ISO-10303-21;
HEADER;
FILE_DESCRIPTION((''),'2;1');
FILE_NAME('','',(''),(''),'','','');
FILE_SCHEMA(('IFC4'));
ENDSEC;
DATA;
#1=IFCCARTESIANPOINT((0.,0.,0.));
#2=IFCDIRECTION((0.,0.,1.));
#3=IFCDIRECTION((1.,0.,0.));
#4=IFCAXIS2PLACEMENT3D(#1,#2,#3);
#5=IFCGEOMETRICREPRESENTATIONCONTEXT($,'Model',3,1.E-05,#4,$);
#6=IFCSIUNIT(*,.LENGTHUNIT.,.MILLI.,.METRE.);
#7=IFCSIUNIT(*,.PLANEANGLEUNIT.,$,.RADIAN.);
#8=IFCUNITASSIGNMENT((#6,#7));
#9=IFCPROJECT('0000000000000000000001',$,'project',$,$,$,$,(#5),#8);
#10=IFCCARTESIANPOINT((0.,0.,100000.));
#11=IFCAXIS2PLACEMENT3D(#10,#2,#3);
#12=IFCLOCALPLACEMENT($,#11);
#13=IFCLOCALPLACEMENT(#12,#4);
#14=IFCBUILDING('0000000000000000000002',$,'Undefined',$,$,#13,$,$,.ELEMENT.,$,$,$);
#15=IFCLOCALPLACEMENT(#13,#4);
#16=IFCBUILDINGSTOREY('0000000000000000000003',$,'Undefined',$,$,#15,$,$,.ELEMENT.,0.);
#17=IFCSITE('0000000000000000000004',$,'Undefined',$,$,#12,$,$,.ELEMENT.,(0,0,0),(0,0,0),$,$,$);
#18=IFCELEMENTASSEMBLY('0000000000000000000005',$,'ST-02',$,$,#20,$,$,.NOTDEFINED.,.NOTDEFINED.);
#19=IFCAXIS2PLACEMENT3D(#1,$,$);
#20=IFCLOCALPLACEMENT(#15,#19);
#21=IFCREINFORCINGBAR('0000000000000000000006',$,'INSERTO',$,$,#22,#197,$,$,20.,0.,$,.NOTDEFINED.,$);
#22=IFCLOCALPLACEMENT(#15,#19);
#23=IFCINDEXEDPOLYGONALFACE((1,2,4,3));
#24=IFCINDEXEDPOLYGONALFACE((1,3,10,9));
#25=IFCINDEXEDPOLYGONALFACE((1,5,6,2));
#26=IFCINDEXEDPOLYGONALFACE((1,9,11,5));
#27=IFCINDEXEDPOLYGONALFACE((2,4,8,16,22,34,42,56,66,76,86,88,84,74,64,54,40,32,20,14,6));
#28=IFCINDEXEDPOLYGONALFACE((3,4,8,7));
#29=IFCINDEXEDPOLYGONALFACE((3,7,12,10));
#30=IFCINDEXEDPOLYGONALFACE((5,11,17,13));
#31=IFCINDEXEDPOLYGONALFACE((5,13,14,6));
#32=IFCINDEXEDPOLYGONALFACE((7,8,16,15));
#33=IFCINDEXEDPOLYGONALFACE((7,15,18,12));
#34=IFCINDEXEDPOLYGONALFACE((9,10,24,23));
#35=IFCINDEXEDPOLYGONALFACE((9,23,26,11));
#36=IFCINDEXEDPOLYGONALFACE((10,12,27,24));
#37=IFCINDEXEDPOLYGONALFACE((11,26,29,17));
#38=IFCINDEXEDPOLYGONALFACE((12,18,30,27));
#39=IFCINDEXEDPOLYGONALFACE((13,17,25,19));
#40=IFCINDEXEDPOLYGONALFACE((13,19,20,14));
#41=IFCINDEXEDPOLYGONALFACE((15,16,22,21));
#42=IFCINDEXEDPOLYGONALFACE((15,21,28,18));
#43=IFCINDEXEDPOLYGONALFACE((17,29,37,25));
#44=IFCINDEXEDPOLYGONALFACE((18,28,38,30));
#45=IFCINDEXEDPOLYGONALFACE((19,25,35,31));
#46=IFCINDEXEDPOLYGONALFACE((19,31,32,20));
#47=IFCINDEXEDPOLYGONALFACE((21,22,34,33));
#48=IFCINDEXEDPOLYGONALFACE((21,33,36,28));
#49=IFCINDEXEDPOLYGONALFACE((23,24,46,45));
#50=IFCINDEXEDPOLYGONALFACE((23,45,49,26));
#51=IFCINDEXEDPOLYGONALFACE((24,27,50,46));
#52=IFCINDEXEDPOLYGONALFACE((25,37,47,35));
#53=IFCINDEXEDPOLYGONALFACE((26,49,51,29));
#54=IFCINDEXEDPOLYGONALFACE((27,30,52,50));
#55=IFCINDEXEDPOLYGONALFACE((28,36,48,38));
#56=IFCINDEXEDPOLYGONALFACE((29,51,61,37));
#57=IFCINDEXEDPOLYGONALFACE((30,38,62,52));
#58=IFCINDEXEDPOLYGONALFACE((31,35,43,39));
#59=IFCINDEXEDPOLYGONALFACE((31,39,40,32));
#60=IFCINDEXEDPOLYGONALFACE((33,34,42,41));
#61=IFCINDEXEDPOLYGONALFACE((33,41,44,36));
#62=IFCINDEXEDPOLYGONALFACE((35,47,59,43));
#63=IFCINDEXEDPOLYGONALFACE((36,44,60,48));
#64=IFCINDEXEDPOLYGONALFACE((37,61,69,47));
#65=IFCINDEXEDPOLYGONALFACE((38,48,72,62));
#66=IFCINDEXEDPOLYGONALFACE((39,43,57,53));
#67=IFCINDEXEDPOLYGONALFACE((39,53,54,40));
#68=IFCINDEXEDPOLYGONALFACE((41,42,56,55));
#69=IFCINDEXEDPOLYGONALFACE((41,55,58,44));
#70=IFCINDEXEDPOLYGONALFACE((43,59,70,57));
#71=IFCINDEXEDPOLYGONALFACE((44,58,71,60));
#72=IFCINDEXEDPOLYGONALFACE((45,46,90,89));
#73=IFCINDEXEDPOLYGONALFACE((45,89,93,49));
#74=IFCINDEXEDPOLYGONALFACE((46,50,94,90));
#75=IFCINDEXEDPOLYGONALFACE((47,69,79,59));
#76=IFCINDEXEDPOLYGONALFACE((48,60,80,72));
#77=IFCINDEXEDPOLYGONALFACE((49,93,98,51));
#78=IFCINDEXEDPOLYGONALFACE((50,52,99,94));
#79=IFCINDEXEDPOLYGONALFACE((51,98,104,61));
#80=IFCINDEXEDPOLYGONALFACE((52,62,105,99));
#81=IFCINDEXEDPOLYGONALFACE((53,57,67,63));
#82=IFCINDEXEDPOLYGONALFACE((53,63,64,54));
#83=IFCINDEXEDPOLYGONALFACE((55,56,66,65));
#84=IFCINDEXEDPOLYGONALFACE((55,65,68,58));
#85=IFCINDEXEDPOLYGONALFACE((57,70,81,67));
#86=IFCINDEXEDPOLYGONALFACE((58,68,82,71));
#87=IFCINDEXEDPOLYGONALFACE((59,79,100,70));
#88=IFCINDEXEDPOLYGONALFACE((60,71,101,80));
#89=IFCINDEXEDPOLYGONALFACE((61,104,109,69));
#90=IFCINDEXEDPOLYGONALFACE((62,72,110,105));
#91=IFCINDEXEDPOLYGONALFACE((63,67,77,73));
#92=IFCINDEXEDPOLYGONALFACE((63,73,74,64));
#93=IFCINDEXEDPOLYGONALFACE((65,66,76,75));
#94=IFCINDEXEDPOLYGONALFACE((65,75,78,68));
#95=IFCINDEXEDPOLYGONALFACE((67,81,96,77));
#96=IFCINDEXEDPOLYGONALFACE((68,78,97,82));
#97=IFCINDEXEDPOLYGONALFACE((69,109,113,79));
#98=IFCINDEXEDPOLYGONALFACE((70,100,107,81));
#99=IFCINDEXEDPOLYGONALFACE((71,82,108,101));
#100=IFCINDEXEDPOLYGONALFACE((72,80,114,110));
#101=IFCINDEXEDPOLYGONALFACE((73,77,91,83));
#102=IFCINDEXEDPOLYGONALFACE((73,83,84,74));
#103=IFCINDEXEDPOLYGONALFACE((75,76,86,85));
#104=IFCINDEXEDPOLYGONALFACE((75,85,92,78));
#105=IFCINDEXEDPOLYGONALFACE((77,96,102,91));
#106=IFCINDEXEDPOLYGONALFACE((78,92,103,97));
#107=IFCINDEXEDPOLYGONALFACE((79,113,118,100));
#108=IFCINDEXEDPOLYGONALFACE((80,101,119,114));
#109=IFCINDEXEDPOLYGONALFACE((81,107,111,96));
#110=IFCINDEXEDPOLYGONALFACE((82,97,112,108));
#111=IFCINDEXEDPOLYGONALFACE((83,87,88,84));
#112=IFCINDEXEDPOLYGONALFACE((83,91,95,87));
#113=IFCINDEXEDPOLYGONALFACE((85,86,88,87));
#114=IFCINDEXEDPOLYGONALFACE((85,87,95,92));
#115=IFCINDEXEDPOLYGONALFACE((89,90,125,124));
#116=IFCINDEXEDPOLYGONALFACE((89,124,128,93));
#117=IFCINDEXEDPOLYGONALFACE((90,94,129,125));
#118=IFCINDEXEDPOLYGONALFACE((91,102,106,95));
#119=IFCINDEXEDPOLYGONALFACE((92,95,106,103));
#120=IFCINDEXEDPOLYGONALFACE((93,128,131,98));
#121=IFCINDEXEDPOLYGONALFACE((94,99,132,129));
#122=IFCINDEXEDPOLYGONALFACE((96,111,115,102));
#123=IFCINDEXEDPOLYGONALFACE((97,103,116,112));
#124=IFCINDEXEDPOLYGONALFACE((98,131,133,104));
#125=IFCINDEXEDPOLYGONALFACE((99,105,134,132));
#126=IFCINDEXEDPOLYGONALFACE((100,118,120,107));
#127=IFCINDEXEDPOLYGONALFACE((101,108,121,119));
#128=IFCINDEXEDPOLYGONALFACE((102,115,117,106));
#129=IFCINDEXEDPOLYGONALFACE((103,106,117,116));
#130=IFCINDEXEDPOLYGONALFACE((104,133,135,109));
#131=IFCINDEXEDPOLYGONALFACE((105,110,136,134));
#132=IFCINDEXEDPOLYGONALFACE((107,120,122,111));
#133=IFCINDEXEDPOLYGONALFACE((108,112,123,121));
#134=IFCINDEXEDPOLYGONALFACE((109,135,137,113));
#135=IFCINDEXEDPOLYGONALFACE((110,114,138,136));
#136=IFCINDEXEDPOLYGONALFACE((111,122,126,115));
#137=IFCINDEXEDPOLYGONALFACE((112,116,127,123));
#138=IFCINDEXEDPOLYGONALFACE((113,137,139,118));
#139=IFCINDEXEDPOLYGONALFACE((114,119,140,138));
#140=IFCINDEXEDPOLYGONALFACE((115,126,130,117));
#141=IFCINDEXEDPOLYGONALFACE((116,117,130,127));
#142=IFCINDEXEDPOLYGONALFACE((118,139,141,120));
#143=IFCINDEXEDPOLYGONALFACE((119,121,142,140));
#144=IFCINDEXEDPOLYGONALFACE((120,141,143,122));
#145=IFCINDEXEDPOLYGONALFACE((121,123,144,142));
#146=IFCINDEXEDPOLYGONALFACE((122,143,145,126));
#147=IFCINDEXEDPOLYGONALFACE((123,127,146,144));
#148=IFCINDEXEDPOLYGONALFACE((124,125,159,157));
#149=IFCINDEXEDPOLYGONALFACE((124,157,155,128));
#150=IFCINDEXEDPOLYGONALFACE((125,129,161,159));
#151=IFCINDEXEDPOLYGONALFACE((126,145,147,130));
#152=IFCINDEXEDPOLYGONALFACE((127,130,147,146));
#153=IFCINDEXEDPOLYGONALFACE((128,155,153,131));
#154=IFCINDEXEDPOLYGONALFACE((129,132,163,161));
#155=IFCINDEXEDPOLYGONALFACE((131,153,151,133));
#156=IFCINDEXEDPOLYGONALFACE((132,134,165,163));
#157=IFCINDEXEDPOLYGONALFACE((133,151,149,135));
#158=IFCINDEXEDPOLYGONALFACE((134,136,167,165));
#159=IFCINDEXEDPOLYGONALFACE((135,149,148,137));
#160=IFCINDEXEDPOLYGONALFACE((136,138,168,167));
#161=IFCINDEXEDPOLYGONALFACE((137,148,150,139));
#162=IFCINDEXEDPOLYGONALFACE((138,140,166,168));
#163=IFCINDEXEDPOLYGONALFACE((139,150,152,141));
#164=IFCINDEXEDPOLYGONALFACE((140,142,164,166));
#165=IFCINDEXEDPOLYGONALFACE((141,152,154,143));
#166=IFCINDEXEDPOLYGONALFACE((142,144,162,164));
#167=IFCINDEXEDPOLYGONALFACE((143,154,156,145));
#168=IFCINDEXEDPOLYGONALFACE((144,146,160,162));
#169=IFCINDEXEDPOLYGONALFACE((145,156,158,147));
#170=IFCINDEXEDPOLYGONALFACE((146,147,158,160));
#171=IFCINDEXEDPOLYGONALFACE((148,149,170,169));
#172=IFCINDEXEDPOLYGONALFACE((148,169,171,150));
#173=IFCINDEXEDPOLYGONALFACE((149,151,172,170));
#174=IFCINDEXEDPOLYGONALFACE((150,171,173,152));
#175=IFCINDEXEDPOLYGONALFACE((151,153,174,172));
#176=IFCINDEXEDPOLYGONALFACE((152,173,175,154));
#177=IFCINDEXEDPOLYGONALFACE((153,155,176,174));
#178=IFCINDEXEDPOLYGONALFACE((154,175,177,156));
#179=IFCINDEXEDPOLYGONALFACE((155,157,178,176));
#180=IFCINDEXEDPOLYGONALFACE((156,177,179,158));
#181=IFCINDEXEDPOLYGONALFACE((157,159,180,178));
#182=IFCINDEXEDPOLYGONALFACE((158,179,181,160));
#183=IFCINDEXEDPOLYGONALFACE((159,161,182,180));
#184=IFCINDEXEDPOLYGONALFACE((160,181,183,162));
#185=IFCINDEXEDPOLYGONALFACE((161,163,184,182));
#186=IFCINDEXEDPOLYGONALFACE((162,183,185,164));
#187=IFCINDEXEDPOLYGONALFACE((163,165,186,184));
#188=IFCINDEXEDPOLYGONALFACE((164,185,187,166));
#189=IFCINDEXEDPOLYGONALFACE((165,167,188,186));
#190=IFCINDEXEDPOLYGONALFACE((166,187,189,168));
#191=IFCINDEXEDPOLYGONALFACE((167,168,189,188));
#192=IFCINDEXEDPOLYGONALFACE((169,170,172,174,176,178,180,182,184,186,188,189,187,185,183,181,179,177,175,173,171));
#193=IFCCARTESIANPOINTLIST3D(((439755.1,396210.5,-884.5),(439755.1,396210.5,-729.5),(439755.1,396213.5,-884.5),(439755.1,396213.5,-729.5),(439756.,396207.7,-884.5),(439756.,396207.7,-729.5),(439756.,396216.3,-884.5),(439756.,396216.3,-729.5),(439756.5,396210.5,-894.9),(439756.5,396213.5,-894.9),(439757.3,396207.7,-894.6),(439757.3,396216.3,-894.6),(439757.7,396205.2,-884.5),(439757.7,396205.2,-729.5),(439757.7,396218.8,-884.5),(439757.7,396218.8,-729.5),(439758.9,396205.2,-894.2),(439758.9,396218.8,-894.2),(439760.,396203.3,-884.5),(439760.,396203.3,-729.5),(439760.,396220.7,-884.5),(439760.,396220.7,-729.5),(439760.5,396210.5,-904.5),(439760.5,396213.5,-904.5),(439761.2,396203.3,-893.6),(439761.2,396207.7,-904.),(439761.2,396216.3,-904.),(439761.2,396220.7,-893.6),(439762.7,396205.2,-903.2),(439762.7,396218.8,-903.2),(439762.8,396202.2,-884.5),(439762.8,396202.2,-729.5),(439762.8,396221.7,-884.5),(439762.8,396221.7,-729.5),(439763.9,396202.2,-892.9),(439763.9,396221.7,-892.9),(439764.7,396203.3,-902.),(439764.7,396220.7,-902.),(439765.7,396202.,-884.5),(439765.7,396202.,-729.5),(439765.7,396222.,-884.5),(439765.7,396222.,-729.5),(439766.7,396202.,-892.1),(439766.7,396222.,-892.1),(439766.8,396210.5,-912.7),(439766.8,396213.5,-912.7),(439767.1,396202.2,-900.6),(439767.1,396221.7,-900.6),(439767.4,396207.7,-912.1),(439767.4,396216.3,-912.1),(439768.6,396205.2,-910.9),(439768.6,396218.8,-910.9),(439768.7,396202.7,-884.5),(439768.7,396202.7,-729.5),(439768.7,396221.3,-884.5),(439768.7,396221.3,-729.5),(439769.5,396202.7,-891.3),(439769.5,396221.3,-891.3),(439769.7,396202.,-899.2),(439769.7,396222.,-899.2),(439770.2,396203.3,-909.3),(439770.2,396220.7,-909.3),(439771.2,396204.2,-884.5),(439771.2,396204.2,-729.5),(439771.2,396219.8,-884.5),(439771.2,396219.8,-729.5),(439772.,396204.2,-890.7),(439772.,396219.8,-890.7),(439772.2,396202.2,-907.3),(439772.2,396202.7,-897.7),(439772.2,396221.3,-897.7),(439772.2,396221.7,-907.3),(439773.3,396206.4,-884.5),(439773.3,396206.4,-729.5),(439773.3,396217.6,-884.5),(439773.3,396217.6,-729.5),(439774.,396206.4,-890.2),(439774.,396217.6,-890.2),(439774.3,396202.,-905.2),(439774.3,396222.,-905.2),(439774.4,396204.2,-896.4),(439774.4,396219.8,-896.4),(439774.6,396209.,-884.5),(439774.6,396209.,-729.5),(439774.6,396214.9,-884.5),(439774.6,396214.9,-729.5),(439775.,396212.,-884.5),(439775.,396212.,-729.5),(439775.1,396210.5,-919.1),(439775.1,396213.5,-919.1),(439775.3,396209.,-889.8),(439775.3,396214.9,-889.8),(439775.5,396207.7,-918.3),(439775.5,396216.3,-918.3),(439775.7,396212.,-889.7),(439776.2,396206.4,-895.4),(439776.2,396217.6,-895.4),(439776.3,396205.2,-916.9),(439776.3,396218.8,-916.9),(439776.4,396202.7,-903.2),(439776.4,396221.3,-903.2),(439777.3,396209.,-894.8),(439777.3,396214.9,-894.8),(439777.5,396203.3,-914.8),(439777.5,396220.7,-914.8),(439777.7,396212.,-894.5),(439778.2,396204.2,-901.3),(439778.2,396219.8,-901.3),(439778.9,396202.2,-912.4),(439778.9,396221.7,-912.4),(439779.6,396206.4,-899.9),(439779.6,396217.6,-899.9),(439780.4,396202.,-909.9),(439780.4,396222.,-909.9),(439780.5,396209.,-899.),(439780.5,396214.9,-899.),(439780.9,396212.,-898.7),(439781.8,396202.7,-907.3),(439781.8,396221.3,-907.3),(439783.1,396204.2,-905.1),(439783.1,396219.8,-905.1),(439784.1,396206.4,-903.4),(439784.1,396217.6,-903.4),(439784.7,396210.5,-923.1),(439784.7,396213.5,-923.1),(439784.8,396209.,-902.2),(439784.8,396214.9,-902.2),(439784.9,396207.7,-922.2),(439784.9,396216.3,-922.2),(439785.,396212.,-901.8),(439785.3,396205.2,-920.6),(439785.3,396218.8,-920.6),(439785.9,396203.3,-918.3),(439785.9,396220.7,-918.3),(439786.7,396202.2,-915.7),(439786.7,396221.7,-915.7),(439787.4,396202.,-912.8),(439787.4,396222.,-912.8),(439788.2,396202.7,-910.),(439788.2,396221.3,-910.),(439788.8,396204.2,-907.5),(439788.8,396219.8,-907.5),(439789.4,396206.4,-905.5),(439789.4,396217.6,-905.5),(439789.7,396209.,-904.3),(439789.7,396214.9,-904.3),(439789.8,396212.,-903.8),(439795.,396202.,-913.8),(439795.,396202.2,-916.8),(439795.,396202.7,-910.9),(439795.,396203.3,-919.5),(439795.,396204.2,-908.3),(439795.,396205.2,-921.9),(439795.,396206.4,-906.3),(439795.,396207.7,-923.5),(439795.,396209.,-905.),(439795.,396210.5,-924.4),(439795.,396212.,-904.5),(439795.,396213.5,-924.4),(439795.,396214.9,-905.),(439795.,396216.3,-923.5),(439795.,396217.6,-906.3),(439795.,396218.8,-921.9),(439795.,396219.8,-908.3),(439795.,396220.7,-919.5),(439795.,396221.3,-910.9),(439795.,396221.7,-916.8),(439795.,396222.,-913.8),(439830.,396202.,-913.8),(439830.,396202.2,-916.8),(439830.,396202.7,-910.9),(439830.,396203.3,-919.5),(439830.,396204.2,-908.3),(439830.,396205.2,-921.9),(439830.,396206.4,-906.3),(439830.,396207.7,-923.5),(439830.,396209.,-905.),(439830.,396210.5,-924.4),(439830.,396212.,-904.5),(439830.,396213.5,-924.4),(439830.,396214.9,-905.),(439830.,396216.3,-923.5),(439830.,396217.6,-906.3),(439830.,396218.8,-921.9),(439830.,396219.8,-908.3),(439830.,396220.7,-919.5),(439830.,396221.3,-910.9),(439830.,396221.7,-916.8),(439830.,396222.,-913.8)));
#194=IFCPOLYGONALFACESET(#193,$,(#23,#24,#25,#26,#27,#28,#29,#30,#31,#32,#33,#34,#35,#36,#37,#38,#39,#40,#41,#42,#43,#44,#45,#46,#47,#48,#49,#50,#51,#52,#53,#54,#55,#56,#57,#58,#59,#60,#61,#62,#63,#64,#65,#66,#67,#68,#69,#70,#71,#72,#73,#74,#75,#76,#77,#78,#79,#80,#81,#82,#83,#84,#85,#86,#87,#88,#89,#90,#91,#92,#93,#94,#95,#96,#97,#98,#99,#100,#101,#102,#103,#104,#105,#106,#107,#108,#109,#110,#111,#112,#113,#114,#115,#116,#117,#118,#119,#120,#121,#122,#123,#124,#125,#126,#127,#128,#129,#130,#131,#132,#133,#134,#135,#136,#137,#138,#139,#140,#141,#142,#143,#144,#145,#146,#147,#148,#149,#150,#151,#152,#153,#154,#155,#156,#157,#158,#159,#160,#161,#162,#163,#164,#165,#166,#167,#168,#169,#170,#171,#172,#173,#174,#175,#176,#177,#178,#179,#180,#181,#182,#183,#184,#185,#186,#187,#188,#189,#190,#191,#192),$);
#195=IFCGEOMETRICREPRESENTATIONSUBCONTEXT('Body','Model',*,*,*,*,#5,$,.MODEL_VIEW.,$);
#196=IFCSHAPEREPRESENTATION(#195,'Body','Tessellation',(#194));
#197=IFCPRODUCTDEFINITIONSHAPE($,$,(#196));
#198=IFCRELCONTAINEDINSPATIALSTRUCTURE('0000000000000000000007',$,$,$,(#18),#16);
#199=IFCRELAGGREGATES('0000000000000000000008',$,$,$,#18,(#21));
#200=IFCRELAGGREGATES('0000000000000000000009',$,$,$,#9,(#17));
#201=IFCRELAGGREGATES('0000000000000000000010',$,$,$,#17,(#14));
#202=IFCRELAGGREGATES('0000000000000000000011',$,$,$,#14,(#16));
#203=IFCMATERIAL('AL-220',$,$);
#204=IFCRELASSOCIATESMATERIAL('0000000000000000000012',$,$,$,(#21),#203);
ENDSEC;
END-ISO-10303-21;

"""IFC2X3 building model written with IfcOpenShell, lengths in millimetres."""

from ifc_helpers import new_model, entity, si_unit, frame, origin_with_axes, place, context, subcontext, project, spatial, source, transform, mapped, material, element, aggregate, save


model = new_model("IFC2X3")

# Units and contexts
model_context = context("Model", 3, precision=1e-05, world=origin_with_axes())
body_context = subcontext(model_context, "Body", "Model", "MODEL_VIEW")
ifc_project = project(units=[si_unit("LENGTHUNIT", "METRE", prefix="MILLI"), si_unit("PLANEANGLEUNIT", "RADIAN")], contexts=[model_context])

# Site, building, storey
site_placement = place(None, frame((0.0, 0.0, 100000.0), z_axis=(0.0, 0.0, 1.0), x_axis=(1.0, 0.0, 0.0)))
site = spatial("IfcSite", under=ifc_project, at=site_placement, Name="Undefined", CompositionType="ELEMENT", RefLatitude=(0, 0, 0), RefLongitude=(0, 0, 0))
building_placement = place(site_placement, origin_with_axes())
building = spatial("IfcBuilding", under=site, at=building_placement, Name="Undefined", CompositionType="ELEMENT")
storey_placement = place(building_placement, origin_with_axes())
storey = spatial("IfcBuildingStorey", under=building, at=storey_placement, Name="Undefined", CompositionType="ELEMENT", Elevation=0.0)

# Element assembly
assembly_1_placement = place(storey_placement, origin_with_axes())
assembly_1 = element("IfcElementAssembly", 1, at=assembly_1_placement, inside=storey, Name="ST-02", AssemblyPlace="NOTDEFINED", PredefinedType="NOTDEFINED")

# Reinforcing bar
ifc_material_1 = material(Name="AL-220")
shared_shape_1 = source(origin_with_axes(), body_context, "Body", "AdvancedSweptSolid", [
    entity("IfcSweptDiskSolid", entity("IfcCompositeCurve", [entity("IfcCompositeCurveSegment", "CONTINUOUS", True, entity("IfcTrimmedCurve", entity("IfcLine", entity("IfcCartesianPoint", [0.0, 0.0, 0.0]), entity("IfcVector", entity("IfcDirection", [1.0, 0.0, 0.0]), 1.0)), [entity("IfcParameterValue", 0.0)], [entity("IfcParameterValue", 155.0)], True, "PARAMETER")), entity("IfcCompositeCurveSegment", "CONTINUOUS", True, entity("IfcTrimmedCurve", entity("IfcCircle", entity("IfcAxis2Placement3D", entity("IfcCartesianPoint", [155.0, 0.0, 30.0]), entity("IfcDirection", [0.0, -1.0, 0.0]), entity("IfcDirection", [0.0, 0.0, -1.0])), 30.0), [entity("IfcParameterValue", 0.0)], [entity("IfcParameterValue", 1.570796)], True, "PARAMETER")), entity("IfcCompositeCurveSegment", "DISCONTINUOUS", True, entity("IfcTrimmedCurve", entity("IfcLine", entity("IfcCartesianPoint", [185.0, 0.0, 30.0]), entity("IfcVector", entity("IfcDirection", [0.0, 0.0, 1.0]), 1.0)), [entity("IfcParameterValue", 0.0)], [entity("IfcParameterValue", 35.0)], True, "PARAMETER"))], False), 10.0, None, 0.0, 191.6),
])
reinforcing_bar_1_placement = place(assembly_1_placement, frame((439765.0, 396212.0, -729.5), z_axis=(1.0, 0.0, 0.0), x_axis=(0.0, 0.0, -1.0)))
reinforcing_bar_1 = element("IfcReinforcingBar", 2, at=reinforcing_bar_1_placement, material=ifc_material_1, Name="INSERTO", BarRole="NOTDEFINED", CrossSectionArea=0.0, NominalDiameter=20.0, context=body_context, shape_type="MappedRepresentation", body=[
    mapped(shared_shape_1, transform((0.0, 0.0, 0.0))),
])
aggregate(assembly_1, [reinforcing_bar_1])

save(model, "model.ifc")
